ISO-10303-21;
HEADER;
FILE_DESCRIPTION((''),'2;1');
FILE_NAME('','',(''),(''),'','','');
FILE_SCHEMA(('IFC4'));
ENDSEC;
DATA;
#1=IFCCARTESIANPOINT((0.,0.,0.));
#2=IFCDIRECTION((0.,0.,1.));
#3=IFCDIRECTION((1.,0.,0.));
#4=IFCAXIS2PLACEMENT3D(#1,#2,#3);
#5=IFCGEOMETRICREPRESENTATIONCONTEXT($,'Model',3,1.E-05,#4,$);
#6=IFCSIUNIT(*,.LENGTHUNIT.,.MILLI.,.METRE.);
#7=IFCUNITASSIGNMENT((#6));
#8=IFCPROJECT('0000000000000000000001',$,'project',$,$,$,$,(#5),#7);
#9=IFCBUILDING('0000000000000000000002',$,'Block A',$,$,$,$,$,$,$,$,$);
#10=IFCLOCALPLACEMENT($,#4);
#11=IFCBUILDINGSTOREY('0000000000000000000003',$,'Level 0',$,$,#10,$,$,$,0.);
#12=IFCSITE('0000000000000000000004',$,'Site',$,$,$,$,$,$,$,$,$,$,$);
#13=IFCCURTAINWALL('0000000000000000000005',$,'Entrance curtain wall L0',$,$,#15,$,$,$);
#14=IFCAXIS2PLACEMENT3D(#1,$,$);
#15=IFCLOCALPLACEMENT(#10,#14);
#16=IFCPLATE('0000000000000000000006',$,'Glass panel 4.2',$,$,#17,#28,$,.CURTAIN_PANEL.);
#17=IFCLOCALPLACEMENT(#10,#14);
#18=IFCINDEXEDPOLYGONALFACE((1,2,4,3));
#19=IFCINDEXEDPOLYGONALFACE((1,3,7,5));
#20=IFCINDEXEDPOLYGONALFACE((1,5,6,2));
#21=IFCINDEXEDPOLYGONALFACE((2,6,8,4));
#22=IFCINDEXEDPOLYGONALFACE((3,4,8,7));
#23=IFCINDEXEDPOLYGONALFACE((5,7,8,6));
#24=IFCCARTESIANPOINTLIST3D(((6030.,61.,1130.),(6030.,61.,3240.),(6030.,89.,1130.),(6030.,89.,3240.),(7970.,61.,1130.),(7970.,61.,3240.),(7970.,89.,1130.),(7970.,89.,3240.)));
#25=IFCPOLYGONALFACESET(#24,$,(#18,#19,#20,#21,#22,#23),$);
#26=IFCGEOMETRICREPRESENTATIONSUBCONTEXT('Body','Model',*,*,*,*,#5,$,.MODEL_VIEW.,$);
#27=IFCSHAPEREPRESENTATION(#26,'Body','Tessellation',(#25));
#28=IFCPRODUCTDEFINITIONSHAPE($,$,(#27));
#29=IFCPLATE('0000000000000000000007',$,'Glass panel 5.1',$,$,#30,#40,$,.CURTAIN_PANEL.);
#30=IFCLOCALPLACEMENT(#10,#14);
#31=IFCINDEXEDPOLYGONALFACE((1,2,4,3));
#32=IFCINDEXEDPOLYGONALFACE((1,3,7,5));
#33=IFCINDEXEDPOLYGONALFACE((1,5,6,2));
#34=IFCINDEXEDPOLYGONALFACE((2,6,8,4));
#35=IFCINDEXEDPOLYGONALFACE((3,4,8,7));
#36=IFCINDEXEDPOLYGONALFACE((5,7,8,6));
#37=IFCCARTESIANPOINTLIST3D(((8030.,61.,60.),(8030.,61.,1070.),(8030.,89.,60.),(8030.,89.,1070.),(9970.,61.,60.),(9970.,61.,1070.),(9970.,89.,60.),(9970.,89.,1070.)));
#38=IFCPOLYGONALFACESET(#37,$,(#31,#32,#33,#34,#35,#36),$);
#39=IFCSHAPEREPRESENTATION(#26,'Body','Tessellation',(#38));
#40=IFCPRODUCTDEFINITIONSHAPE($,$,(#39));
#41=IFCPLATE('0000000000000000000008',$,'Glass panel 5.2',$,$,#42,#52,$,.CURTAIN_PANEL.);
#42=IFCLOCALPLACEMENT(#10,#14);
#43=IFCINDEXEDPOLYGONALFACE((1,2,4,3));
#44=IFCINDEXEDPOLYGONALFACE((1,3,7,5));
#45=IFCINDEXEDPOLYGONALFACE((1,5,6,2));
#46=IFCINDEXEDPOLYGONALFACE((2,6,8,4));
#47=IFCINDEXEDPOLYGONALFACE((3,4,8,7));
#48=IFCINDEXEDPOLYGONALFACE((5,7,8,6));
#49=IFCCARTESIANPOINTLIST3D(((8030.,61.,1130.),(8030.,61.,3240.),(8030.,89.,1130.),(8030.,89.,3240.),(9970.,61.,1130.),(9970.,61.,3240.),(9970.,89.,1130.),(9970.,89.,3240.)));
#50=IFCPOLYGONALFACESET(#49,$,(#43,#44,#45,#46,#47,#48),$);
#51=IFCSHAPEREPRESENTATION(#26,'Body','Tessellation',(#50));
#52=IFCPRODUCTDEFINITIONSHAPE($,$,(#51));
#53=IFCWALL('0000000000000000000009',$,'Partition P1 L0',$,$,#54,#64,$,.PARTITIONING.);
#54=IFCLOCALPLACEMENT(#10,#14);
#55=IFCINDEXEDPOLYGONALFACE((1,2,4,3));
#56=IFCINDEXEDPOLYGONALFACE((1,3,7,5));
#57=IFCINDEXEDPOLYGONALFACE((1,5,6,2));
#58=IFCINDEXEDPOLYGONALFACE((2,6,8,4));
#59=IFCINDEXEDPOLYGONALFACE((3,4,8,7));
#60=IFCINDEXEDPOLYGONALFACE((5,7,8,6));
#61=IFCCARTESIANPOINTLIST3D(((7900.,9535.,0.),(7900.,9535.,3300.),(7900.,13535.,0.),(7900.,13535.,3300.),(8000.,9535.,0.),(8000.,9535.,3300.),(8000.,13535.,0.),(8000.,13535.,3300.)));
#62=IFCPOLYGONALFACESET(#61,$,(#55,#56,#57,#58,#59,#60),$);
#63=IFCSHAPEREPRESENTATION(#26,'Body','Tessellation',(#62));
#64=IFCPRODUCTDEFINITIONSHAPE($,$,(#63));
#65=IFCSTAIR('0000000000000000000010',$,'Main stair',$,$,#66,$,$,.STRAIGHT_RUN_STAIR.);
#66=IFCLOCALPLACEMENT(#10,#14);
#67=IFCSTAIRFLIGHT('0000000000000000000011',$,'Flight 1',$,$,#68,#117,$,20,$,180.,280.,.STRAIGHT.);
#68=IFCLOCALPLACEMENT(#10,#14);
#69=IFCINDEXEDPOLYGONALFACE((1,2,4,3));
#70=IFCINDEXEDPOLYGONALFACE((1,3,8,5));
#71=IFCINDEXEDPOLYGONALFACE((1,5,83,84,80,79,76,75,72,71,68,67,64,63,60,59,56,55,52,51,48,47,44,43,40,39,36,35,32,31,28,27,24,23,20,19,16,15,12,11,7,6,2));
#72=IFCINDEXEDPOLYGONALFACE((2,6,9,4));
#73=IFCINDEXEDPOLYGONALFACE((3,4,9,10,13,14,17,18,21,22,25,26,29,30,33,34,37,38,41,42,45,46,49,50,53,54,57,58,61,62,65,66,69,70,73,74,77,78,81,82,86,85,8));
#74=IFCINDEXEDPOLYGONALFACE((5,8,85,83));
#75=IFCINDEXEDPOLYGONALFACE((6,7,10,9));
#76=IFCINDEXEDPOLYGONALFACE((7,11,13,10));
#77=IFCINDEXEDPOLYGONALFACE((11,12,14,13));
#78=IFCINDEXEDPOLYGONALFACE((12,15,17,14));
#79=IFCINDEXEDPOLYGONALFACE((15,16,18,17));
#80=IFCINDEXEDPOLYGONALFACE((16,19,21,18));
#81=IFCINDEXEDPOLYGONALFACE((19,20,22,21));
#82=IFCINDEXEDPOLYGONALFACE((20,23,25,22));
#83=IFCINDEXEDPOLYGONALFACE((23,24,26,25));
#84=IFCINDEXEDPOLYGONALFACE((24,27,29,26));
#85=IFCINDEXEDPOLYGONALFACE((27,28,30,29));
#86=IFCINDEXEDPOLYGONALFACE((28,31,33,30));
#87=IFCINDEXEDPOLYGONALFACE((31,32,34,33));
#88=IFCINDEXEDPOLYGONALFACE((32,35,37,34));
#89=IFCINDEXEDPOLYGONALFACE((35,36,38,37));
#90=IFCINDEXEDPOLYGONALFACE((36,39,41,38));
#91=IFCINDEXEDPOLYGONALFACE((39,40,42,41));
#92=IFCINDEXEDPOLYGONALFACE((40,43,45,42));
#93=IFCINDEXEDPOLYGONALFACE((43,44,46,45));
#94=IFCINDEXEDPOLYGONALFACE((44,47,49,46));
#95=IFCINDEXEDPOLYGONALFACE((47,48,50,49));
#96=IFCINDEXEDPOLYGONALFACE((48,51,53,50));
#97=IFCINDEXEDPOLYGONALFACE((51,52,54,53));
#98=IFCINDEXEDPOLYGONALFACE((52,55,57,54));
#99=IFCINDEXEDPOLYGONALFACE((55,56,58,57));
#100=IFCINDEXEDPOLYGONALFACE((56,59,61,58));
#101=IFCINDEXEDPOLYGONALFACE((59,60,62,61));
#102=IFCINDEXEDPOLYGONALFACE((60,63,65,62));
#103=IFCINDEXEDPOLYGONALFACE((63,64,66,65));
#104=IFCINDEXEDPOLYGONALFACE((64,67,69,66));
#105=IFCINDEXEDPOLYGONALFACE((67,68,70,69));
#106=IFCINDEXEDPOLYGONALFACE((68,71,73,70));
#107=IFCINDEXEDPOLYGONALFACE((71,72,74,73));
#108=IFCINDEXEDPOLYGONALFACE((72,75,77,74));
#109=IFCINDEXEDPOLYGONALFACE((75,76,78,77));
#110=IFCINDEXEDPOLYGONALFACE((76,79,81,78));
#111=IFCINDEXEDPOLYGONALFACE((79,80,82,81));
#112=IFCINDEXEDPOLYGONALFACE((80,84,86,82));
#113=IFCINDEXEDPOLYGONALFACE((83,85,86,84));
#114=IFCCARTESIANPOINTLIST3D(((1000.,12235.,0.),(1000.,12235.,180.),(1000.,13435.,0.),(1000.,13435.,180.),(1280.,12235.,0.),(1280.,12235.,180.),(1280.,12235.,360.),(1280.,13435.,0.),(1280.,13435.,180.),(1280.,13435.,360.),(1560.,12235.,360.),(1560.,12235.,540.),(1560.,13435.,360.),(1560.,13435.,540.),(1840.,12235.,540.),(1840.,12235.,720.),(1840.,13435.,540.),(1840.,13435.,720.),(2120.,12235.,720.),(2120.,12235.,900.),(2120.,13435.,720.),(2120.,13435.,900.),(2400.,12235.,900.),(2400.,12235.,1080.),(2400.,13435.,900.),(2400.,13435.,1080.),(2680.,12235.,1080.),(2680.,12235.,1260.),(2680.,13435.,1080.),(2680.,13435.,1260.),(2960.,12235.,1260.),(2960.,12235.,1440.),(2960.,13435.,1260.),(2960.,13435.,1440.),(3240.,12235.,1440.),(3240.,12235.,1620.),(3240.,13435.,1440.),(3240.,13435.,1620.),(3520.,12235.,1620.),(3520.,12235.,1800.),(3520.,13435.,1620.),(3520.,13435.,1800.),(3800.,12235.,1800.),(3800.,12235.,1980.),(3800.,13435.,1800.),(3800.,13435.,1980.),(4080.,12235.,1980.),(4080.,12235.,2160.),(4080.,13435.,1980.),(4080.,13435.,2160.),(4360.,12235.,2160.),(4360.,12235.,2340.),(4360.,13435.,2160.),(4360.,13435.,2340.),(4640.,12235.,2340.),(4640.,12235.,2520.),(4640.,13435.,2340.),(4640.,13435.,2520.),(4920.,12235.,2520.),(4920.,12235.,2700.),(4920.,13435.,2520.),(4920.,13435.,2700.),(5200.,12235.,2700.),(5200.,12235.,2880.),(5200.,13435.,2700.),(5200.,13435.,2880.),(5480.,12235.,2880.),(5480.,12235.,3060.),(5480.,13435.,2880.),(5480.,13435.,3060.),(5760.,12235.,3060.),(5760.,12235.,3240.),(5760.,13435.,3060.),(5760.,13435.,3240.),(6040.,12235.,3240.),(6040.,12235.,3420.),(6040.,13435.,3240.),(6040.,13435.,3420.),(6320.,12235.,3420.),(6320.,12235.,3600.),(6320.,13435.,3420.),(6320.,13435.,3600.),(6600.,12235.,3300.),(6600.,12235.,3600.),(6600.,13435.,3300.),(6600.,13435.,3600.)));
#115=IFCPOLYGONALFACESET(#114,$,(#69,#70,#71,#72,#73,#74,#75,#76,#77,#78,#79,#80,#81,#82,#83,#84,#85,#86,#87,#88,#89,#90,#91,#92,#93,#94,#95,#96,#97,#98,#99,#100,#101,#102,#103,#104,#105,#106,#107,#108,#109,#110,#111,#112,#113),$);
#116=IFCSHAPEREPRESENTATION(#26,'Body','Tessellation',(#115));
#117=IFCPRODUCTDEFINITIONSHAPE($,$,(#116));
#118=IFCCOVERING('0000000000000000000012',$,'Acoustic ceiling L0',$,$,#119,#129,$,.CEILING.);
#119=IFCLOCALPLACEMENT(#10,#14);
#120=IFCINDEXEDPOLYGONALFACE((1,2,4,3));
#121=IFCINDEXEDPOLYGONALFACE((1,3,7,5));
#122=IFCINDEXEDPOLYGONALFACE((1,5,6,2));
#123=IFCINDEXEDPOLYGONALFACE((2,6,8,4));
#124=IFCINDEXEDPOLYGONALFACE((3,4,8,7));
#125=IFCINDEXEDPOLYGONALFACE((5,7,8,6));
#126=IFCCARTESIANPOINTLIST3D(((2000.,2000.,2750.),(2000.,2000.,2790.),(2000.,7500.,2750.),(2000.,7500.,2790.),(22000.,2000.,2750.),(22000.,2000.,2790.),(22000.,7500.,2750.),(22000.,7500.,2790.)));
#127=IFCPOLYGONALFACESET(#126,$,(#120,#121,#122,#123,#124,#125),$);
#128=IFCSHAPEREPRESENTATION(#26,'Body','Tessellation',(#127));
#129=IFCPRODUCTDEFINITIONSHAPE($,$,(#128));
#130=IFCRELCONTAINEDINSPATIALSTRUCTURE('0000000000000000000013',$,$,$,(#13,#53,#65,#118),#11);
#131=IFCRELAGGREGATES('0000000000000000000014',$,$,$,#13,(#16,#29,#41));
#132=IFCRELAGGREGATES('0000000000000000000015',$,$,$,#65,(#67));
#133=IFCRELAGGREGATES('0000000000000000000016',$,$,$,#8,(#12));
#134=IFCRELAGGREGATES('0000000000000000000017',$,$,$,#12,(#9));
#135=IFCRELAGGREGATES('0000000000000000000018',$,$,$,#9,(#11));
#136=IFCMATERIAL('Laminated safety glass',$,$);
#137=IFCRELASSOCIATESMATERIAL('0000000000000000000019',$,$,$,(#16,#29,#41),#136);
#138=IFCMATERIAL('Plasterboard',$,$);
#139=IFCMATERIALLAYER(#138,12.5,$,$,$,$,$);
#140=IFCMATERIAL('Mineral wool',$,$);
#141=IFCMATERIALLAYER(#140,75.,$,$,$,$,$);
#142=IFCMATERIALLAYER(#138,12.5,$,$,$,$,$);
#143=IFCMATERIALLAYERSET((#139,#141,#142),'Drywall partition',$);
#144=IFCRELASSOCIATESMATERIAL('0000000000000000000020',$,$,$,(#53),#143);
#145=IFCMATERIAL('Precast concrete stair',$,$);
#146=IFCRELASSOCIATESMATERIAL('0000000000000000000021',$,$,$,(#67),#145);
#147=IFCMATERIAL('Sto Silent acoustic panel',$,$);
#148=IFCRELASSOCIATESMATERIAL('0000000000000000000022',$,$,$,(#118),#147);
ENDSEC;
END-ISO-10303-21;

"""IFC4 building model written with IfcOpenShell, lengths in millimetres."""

from ifc_helpers import new_model, si_unit, frame, origin_with_axes, place, context, subcontext, project, spatial, polyline, indexed_curve, outline, extrude, material, layer, layer_set, layer_usage, element, aggregate, save


model = new_model("IFC4")

# Units and contexts
model_context = context("Model", 3, precision=1e-05, world=origin_with_axes())
body_context = subcontext(model_context, "Body", "Model", "MODEL_VIEW")
ifc_project = project(units=[si_unit("LENGTHUNIT", "METRE", prefix="MILLI")], contexts=[model_context])

# Site, building, storey
site = spatial("IfcSite", under=ifc_project, Name="Site")
building = spatial("IfcBuilding", under=site, Name="Block A")
storey_placement = place(None, origin_with_axes())
storey = spatial("IfcBuildingStorey", under=building, at=storey_placement, Name="Level 0", Elevation=0.0)

# Curtain wall
curtain_wall_placement = place(storey_placement, origin_with_axes())
curtain_wall = element("IfcCurtainWall", 1, at=curtain_wall_placement, inside=storey, Name="Entrance curtain wall L0")

# Plates
ifc_material_1 = material(Name="Laminated safety glass")
plate_1_placement = place(curtain_wall_placement, frame((6030.0, 61.0, 1130.0), z_axis=(0.0, 0.0, 1.0), x_axis=(1.0, 0.0, 0.0)))
plate_1 = element("IfcPlate", 2, at=plate_1_placement, material=ifc_material_1, Name="Glass panel 4.2", PredefinedType="CURTAIN_PANEL", context=body_context, shape_type="SweptSolid", body=[
    extrude(outline(indexed_curve([(0.0, 0.0), (0.0, 28.0), (1940.0, 28.0), (1940.0, 0.0), (0.0, 0.0)], self_intersect=False)), origin_with_axes(), (0.0, 0.0, 1.0), 2110.0),
])
plate_2_placement = place(curtain_wall_placement, frame((8030.0, 61.0, 60.0), z_axis=(0.0, 0.0, 1.0), x_axis=(1.0, 0.0, 0.0)))
plate_2 = element("IfcPlate", 3, at=plate_2_placement, material=ifc_material_1, Name="Glass panel 5.1", PredefinedType="CURTAIN_PANEL", context=body_context, shape_type="SweptSolid", body=[
    extrude(outline(indexed_curve([(0.0, 0.0), (0.0, 28.0), (1940.0, 28.0), (1940.0, 0.0), (0.0, 0.0)], self_intersect=False)), origin_with_axes(), (0.0, 0.0, 1.0), 1010.0),
])
plate_3_placement = place(curtain_wall_placement, frame((8030.0, 61.0, 1130.0), z_axis=(0.0, 0.0, 1.0), x_axis=(1.0, 0.0, 0.0)))
plate_3 = element("IfcPlate", 4, at=plate_3_placement, material=ifc_material_1, Name="Glass panel 5.2", PredefinedType="CURTAIN_PANEL", context=body_context, shape_type="SweptSolid", body=[
    extrude(outline(indexed_curve([(0.0, 0.0), (0.0, 28.0), (1940.0, 28.0), (1940.0, 0.0), (0.0, 0.0)], self_intersect=False)), origin_with_axes(), (0.0, 0.0, 1.0), 2110.0),
])
aggregate(curtain_wall, [plate_1, plate_2, plate_3])

# Shared definitions
ifc_material_2 = material(Name="Mineral wool")

# Wall
ifc_material_3 = material(Name="Plasterboard")
ifc_layer_1 = layer(ifc_material_3, 12.5)
ifc_layer_2 = layer(ifc_material_2, 75.0)
ifc_layer_3 = layer(ifc_material_3, 12.5)
ifc_layer_set_1 = layer_set([ifc_layer_1, ifc_layer_2, ifc_layer_3], Name="Drywall partition")
ifc_layer_usage_1 = layer_usage(ifc_layer_set_1, "AXIS2", "POSITIVE", 0.0)
wall_1_placement = place(storey_placement, frame((8000.0, 9535.0, 0.0), z_axis=(0.0, 0.0, 1.0), x_axis=(0.0, 1.0, 0.0)))
element("IfcWall", 5, at=wall_1_placement, inside=storey, material=ifc_layer_usage_1, Name="Partition P1 L0", PredefinedType="PARTITIONING", context=body_context, shape_type="SweptSolid", body=[
    extrude(outline(indexed_curve([(0.0, 0.0), (0.0, 100.0), (4000.0, 100.0), (4000.0, 0.0), (0.0, 0.0)], self_intersect=False)), origin_with_axes(), (0.0, 0.0, 1.0), 3300.0),
])

# Stair, stair flight
stair_placement = place(storey_placement, frame((1000.0, 13435.0, 0.0), z_axis=(0.0, 0.0, 1.0), x_axis=(1.0, 0.0, 0.0)))
stair = element("IfcStair", 6, at=stair_placement, inside=storey, Name="Main stair", PredefinedType="STRAIGHT_RUN_STAIR")
ifc_material_4 = material(Name="Precast concrete stair")
stair_flight_placement = place(stair_placement, frame((0.0, 0.0, 0.0), z_axis=(0.0, -1.0, 0.0), x_axis=(1.0, 0.0, 0.0)))
stair_flight = element("IfcStairFlight", 7, at=stair_flight_placement, material=ifc_material_4, Name="Flight 1", NumberOfRisers=20, PredefinedType="STRAIGHT", RiserHeight=180.0, TreadLength=280.0, context=body_context, shape_type="SweptSolid", body=[
    extrude(outline(polyline([(0.0, 0.0), (0.0, 180.0), (280.0, 180.0), (280.0, 360.0), (560.0, 360.0), (560.0, 540.0), (840.0, 540.0), (840.0, 720.0), (1120.0, 720.0), (1120.0, 900.0), (1400.0, 900.0), (1400.0, 1080.0), (1680.0, 1080.0), (1680.0, 1260.0), (1960.0, 1260.0), (1960.0, 1440.0), (2240.0, 1440.0), (2240.0, 1620.0), (2520.0, 1620.0), (2520.0, 1800.0), (2800.0, 1800.0), (2800.0, 1980.0), (3080.0, 1980.0), (3080.0, 2160.0), (3360.0, 2160.0), (3360.0, 2340.0), (3640.0, 2340.0), (3640.0, 2520.0), (3920.0, 2520.0), (3920.0, 2700.0), (4200.0, 2700.0), (4200.0, 2880.0), (4480.0, 2880.0), (4480.0, 3060.0), (4760.0, 3060.0), (4760.0, 3240.0), (5040.0, 3240.0), (5040.0, 3420.0), (5320.0, 3420.0), (5320.0, 3600.0), (5600.0, 3600.0), (5600.0, 3300.0), (280.0, 0.0), (0.0, 0.0)])), origin_with_axes(), (0.0, 0.0, 1.0), 1200.0),
])
aggregate(stair, [stair_flight])

# Covering
ifc_material_5 = material(Name="Sto Silent acoustic panel")
covering_placement = place(storey_placement, frame((0.0, 0.0, 2750.0), z_axis=(0.0, 0.0, 1.0), x_axis=(1.0, 0.0, 0.0)))
element("IfcCovering", 8, at=covering_placement, inside=storey, material=ifc_material_5, Name="Acoustic ceiling L0", PredefinedType="CEILING", context=body_context, shape_type="SweptSolid", body=[
    extrude(outline(indexed_curve([(2000.0, 2000.0), (22000.0, 2000.0), (22000.0, 7500.0), (2000.0, 7500.0), (2000.0, 2000.0)])), None, (0.0, 0.0, 1.0), 40.0),
])

save(model, "model.ifc")
